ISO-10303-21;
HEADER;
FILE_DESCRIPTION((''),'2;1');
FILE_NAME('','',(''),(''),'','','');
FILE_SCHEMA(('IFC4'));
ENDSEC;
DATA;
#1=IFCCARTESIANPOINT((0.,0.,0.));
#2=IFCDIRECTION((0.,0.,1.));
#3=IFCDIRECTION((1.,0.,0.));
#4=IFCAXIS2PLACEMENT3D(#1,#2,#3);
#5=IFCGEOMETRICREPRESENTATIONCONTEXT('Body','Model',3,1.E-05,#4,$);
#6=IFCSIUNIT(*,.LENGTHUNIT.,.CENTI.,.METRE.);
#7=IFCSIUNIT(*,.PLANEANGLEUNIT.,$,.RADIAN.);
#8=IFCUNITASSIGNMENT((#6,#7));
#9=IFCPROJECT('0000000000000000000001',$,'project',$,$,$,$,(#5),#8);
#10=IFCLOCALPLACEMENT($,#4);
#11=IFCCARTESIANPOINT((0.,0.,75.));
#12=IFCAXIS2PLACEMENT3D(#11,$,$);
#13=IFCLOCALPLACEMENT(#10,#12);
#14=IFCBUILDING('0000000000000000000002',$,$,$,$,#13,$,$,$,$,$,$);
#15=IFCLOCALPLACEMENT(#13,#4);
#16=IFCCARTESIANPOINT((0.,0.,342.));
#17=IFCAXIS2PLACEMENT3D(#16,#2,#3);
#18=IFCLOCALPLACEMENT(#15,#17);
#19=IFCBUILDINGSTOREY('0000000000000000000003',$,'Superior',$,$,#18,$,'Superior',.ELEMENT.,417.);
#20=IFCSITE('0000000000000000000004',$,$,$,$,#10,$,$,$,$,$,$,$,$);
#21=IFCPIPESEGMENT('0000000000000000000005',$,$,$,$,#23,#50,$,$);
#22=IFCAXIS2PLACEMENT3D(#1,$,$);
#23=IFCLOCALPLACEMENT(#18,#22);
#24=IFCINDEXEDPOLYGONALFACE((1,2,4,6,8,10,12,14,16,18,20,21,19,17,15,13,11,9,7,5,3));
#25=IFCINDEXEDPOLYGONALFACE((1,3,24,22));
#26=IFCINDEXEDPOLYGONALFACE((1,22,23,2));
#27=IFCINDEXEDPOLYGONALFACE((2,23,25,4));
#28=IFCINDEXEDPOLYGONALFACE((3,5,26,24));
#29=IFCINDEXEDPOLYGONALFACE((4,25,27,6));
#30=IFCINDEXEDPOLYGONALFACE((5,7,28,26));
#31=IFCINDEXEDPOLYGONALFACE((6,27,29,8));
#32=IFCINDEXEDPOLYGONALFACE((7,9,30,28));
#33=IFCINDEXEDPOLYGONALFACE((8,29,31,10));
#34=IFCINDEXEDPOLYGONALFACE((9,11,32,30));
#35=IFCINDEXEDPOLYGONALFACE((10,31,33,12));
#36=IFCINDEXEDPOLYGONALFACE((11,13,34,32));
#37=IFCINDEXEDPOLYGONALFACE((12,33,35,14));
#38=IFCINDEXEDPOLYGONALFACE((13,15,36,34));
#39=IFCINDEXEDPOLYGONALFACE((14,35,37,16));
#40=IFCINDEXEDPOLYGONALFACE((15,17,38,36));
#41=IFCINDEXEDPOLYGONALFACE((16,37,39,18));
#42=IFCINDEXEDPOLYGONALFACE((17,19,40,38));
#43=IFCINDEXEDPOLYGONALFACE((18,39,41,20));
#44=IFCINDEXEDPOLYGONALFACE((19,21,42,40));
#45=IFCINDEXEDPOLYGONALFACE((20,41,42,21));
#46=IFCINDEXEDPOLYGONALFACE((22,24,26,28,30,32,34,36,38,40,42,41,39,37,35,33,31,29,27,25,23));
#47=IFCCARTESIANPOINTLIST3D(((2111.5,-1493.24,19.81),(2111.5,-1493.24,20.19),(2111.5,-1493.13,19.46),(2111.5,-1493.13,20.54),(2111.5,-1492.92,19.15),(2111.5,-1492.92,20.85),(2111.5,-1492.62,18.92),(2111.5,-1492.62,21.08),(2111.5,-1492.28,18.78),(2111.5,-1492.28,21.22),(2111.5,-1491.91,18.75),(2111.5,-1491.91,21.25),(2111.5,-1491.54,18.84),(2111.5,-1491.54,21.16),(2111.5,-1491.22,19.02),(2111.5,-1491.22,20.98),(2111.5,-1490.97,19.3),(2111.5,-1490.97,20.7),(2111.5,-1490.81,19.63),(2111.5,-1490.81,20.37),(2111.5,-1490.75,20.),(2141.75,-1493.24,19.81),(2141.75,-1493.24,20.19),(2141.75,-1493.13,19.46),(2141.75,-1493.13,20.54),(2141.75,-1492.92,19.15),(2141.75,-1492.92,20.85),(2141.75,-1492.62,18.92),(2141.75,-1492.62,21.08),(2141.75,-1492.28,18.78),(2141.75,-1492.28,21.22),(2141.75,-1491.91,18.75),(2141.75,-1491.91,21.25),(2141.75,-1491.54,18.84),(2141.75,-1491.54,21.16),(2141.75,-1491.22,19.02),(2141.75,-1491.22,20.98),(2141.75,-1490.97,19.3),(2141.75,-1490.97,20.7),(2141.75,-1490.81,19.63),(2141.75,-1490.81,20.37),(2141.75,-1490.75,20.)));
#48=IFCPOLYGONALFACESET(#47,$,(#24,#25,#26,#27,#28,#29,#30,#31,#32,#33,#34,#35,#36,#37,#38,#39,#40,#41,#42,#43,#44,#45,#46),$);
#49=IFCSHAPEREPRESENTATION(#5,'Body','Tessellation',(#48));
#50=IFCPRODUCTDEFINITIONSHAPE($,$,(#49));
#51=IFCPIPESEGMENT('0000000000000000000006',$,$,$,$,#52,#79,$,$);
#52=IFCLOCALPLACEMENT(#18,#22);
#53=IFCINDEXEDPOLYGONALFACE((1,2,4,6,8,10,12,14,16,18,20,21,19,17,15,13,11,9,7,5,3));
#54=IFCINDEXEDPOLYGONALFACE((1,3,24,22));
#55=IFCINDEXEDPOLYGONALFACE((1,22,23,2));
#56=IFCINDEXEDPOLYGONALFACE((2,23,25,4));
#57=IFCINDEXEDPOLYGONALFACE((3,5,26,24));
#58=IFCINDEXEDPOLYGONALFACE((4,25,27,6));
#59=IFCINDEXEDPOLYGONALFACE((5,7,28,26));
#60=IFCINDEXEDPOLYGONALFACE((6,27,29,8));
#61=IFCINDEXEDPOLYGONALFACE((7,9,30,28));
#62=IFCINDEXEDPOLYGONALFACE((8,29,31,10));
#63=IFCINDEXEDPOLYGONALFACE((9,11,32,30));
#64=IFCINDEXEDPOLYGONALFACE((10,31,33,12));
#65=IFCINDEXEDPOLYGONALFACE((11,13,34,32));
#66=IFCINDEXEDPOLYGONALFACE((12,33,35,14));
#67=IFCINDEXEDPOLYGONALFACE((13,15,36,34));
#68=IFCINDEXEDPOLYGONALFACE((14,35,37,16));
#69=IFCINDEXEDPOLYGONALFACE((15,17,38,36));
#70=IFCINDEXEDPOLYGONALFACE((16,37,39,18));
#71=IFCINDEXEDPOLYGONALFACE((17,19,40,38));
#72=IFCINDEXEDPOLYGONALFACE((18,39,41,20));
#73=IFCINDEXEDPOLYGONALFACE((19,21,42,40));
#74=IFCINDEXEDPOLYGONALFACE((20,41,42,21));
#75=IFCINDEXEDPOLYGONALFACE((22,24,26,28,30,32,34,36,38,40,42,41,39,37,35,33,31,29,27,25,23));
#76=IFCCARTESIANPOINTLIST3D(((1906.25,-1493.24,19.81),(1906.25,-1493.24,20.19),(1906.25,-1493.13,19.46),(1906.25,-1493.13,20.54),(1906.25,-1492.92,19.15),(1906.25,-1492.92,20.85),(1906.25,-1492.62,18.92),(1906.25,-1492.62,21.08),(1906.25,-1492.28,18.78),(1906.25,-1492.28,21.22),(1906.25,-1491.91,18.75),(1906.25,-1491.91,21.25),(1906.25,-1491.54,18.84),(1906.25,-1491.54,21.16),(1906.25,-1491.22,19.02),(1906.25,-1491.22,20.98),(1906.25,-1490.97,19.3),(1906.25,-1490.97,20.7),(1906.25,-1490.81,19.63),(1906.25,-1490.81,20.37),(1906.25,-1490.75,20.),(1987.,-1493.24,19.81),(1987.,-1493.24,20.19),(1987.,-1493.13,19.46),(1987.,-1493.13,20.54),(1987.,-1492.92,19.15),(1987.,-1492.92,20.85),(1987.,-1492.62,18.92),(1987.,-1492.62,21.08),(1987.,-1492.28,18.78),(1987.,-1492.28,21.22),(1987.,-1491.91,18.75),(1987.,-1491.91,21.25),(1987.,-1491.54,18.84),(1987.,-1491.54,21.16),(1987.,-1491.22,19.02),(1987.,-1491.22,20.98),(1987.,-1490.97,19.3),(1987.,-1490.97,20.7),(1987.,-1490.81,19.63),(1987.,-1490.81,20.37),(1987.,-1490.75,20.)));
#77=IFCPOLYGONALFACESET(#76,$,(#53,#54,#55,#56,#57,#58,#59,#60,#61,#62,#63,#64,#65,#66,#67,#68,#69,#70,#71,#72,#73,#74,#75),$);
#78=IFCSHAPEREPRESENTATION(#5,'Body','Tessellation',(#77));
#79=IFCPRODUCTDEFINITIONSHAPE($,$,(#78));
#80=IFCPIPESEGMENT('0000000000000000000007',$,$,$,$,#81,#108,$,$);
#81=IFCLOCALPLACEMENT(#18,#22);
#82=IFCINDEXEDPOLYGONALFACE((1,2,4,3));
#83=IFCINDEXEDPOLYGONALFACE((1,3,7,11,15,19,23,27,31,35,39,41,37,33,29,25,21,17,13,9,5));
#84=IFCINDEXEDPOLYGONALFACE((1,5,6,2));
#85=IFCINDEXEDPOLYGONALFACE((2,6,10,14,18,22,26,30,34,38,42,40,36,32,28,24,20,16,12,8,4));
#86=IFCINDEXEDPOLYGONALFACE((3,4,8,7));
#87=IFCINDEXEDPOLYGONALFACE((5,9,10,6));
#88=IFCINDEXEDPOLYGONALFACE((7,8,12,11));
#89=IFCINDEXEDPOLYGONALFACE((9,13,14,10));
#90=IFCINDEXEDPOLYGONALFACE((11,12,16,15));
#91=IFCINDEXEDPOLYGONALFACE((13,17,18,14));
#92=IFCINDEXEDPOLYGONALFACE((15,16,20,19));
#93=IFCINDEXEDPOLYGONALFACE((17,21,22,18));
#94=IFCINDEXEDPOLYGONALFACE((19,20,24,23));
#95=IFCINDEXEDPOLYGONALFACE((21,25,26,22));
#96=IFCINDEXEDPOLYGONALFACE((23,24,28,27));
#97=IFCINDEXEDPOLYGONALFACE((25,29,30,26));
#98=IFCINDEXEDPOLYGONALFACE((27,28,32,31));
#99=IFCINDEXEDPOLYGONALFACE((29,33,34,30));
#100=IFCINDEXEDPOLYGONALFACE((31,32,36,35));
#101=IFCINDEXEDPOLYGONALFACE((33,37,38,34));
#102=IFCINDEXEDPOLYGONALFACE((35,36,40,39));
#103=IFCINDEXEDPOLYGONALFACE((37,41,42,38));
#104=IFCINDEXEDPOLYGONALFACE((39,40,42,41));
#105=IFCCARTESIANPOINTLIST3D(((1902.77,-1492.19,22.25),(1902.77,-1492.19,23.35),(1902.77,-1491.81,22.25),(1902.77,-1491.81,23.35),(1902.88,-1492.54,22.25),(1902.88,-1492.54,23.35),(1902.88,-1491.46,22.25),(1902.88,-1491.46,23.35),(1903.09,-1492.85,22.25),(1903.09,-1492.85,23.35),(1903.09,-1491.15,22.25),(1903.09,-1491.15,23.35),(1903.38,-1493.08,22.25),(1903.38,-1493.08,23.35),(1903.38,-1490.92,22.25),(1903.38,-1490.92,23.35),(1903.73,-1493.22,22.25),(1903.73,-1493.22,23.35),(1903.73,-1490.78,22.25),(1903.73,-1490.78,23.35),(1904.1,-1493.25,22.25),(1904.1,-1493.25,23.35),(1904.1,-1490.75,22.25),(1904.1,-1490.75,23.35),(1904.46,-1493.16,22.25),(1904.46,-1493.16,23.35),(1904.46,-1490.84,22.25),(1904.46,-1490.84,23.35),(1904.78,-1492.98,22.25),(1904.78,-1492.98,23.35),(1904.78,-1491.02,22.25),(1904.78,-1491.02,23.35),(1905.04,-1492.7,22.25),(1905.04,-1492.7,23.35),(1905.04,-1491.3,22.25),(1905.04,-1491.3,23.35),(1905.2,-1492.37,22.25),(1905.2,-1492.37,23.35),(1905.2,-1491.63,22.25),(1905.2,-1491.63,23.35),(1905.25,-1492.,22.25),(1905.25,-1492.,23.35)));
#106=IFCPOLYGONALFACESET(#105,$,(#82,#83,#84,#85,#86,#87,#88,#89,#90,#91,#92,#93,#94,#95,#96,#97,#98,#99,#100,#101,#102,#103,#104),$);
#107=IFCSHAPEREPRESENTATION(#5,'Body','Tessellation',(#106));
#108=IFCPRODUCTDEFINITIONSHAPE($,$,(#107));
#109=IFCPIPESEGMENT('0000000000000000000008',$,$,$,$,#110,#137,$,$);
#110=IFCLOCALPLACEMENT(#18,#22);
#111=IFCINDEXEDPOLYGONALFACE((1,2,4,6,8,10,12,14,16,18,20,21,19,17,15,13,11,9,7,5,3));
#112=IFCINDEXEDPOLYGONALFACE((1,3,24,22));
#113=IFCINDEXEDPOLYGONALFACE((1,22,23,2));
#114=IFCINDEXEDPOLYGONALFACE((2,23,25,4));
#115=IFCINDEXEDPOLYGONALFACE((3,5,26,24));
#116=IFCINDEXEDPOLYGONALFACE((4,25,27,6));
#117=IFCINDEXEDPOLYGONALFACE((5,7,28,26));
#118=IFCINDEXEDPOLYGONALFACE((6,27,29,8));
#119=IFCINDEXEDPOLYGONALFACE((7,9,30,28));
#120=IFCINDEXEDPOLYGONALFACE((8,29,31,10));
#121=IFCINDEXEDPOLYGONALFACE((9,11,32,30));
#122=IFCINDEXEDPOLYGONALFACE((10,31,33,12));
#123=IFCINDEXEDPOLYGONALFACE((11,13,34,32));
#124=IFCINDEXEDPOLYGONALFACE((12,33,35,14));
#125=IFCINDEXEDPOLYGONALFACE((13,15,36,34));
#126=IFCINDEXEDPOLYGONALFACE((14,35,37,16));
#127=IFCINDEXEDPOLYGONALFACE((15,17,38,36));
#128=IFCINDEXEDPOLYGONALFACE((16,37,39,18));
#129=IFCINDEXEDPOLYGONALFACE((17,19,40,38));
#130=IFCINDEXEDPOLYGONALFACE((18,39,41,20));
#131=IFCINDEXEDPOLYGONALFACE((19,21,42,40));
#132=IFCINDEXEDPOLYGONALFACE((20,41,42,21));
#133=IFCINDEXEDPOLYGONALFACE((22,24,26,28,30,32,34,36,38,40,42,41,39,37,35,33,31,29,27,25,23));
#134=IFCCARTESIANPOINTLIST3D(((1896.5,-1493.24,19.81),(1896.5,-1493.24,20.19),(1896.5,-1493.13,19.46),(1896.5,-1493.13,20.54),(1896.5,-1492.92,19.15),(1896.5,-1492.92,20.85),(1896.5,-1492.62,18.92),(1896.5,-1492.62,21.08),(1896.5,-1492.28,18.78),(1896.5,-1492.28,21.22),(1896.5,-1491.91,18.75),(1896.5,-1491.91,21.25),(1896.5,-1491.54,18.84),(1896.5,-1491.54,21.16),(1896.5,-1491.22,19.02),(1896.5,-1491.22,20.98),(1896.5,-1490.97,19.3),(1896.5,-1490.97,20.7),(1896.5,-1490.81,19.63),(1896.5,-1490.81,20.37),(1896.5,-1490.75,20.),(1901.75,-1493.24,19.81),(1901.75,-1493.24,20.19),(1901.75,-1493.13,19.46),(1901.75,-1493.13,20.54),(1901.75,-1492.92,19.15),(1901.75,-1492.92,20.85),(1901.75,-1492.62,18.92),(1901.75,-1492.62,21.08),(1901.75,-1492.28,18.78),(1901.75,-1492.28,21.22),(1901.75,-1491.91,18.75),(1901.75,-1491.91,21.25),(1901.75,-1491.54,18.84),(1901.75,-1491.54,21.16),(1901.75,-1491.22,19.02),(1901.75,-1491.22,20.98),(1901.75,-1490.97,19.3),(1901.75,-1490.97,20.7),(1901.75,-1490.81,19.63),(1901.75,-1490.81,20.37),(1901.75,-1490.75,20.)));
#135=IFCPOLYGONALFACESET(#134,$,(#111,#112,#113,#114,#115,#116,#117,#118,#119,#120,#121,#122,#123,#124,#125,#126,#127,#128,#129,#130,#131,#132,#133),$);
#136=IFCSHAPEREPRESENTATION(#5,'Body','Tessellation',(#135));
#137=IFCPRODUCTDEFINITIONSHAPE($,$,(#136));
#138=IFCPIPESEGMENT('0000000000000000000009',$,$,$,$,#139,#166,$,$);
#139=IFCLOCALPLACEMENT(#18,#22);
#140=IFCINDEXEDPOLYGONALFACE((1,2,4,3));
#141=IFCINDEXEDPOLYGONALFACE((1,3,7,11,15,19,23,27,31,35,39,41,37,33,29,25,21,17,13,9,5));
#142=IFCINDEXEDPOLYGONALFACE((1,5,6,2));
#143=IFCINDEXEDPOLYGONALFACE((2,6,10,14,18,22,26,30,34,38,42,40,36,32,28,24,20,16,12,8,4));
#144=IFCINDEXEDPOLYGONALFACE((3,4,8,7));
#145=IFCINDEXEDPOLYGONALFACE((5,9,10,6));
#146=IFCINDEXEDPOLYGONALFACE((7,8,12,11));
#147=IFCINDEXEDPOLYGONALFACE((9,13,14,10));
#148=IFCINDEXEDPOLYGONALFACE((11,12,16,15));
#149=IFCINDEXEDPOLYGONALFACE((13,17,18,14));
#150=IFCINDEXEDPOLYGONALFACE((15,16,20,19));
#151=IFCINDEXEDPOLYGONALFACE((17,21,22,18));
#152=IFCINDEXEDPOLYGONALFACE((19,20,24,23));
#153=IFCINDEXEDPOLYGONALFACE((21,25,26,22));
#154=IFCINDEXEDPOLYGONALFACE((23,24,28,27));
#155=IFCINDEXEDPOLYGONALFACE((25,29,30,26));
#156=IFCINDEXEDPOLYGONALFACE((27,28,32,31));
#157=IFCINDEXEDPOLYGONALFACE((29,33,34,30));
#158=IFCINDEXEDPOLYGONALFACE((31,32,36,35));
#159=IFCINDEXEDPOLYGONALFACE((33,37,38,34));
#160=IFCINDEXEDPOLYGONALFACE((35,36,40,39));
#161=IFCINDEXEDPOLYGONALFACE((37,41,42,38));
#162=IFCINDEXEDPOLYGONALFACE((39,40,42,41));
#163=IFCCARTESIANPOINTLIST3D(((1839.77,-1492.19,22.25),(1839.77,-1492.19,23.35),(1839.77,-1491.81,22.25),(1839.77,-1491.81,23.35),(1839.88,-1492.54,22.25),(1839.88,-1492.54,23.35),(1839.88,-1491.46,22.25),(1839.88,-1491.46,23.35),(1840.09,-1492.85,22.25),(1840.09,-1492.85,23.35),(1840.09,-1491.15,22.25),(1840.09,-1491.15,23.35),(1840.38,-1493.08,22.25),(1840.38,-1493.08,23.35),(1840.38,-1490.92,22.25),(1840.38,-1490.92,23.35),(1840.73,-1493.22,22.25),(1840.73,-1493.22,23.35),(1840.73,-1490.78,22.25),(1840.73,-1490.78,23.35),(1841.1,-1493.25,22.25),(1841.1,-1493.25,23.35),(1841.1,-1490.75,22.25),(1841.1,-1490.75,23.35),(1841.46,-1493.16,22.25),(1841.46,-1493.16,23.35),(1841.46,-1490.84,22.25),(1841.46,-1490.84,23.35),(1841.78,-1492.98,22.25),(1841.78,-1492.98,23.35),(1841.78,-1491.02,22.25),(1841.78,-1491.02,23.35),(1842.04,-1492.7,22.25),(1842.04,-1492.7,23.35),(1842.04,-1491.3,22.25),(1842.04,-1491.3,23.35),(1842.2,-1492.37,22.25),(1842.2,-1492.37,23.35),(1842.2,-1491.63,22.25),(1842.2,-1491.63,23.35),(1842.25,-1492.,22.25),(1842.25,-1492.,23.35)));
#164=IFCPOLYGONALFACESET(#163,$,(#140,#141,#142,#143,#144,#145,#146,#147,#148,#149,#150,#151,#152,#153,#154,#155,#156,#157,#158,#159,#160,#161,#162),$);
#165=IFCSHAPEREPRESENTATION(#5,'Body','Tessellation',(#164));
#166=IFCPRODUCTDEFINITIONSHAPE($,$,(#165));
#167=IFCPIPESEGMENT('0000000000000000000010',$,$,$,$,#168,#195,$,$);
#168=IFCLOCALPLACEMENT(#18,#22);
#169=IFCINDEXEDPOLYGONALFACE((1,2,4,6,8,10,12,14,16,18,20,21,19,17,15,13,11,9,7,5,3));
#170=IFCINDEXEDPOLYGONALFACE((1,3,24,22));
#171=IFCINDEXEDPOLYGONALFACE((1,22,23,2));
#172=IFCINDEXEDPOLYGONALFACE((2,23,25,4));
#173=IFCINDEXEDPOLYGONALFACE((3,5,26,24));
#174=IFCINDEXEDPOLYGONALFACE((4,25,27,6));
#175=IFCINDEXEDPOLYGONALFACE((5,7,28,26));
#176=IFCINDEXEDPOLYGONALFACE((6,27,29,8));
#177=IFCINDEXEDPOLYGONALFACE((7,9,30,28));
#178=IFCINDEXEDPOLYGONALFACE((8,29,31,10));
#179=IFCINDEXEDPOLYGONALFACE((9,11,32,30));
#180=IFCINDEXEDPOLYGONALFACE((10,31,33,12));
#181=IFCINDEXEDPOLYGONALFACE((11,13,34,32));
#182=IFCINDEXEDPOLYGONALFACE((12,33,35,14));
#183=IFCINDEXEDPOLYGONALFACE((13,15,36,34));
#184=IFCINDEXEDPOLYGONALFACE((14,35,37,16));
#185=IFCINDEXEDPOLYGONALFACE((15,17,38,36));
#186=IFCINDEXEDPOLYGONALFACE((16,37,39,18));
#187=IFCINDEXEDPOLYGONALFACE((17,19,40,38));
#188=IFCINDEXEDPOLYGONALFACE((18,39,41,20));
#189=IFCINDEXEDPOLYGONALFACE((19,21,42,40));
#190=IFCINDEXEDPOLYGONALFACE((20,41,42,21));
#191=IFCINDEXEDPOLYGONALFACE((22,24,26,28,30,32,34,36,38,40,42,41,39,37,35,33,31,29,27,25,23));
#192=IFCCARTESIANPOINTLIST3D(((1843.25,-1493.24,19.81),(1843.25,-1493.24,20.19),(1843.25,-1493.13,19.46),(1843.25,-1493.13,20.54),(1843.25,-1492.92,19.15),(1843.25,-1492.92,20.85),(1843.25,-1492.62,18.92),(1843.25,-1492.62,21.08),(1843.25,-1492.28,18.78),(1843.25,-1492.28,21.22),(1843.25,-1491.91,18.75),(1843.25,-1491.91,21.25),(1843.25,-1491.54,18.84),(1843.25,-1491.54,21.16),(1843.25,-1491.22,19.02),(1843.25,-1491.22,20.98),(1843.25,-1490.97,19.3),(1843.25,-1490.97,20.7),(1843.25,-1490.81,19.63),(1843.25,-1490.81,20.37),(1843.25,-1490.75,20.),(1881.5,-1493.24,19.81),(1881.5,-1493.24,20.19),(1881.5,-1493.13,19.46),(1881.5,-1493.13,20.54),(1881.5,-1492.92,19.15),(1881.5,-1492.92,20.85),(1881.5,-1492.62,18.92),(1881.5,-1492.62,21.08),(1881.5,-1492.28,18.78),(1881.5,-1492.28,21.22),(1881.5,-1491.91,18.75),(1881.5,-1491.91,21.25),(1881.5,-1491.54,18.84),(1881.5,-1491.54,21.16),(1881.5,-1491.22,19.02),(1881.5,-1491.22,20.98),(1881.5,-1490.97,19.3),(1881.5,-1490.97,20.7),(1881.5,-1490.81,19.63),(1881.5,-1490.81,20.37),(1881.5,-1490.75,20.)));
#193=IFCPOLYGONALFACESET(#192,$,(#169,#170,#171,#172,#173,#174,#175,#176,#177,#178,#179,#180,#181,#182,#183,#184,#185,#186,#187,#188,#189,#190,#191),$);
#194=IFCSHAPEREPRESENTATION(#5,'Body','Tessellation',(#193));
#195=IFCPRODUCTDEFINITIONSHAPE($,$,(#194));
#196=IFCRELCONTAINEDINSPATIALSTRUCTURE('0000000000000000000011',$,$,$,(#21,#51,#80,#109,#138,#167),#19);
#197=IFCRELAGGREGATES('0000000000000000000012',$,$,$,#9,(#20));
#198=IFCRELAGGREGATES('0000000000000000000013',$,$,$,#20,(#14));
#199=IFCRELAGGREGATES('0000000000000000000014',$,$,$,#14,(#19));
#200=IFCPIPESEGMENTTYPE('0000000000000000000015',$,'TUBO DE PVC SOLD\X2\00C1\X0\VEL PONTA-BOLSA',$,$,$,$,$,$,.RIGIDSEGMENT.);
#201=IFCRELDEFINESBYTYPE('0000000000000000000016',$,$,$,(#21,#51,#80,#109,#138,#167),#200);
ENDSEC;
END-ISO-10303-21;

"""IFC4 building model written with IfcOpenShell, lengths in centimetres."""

from ifc_helpers import new_model, si_unit, frame, origin_with_axes, origin_2d_with_axis, place, context, project, spatial, circle, extrude, type_object, element, save


model = new_model("IFC4")

# Units and contexts
model_context = context("Model", 3, precision=1e-05, world=origin_with_axes(), identifier="Body")
ifc_project = project(units=[si_unit("LENGTHUNIT", "METRE", prefix="CENTI"), si_unit("PLANEANGLEUNIT", "RADIAN")], contexts=[model_context])

# Site, building, storey
site_placement = place(None, origin_with_axes())
site = spatial("IfcSite", under=ifc_project, at=site_placement)
building_placement = place(site_placement, frame((0.0, 0.0, 75.0)))
building = spatial("IfcBuilding", under=site, at=building_placement)
placement = place(building_placement, origin_with_axes())
storey_placement = place(placement, frame((0.0, 0.0, 342.0), z_axis=(0.0, 0.0, 1.0), x_axis=(1.0, 0.0, 0.0)))
storey = spatial("IfcBuildingStorey", under=building, at=storey_placement, Name="Superior", LongName="Superior", CompositionType="ELEMENT", Elevation=417.0)

# Pipe segments
pipe_segment_type_1 = type_object("IfcPipeSegmentType", Name="TUBO DE PVC SOLDÁVEL PONTA-BOLSA", PredefinedType="RIGIDSEGMENT")
pipe_segment_1_placement = place(storey_placement, frame((2126.63, -1492.0, 21.25), z_axis=(0.0, 0.0, 1.0), x_axis=(1.0, 0.0, 0.0)))
element("IfcPipeSegment", 1, at=pipe_segment_1_placement, inside=storey, type_object=pipe_segment_type_1, context=model_context, shape_type="SolidModel", body=[
    extrude(circle(Radius=1.25, at=origin_2d_with_axis()), frame((15.12, 0.0, -1.25), z_axis=(-1.0, 0.0, 0.0), x_axis=(0.0, 1.0, 0.0)), (0.0, 0.0, 1.0), 30.25),
])
pipe_segment_2_placement = place(storey_placement, frame((1946.63, -1492.0, 21.25), z_axis=(0.0, 0.0, 1.0), x_axis=(1.0, 0.0, 0.0)))
element("IfcPipeSegment", 2, at=pipe_segment_2_placement, inside=storey, type_object=pipe_segment_type_1, context=model_context, shape_type="SolidModel", body=[
    extrude(circle(Radius=1.25, at=origin_2d_with_axis()), frame((40.38, 0.0, -1.25), z_axis=(-1.0, 0.0, 0.0), x_axis=(0.0, 1.0, 0.0)), (0.0, 0.0, 1.0), 80.75),
])
pipe_segment_3_placement = place(storey_placement, frame((1904.0, -1492.0, 23.35), z_axis=(0.0, 0.0, 1.0), x_axis=(1.0, 0.0, 0.0)))
element("IfcPipeSegment", 3, at=pipe_segment_3_placement, inside=storey, type_object=pipe_segment_type_1, context=model_context, shape_type="SolidModel", body=[
    extrude(circle(Radius=1.25, at=origin_2d_with_axis()), frame((0.0, 0.0, -1.1), z_axis=(0.0, 0.0, 1.0), x_axis=(1.0, 0.0, 0.0)), (0.0, 0.0, 1.0), 1.1),
])
pipe_segment_4_placement = place(storey_placement, frame((1899.13, -1492.0, 21.25), z_axis=(0.0, 0.0, 1.0), x_axis=(1.0, 0.0, 0.0)))
element("IfcPipeSegment", 4, at=pipe_segment_4_placement, inside=storey, type_object=pipe_segment_type_1, context=model_context, shape_type="SolidModel", body=[
    extrude(circle(Radius=1.25, at=origin_2d_with_axis()), frame((2.62, 0.0, -1.25), z_axis=(-1.0, 0.0, 0.0), x_axis=(0.0, 1.0, 0.0)), (0.0, 0.0, 1.0), 5.25),
])
pipe_segment_5_placement = place(storey_placement, frame((1841.0, -1492.0, 23.35), z_axis=(0.0, 0.0, 1.0), x_axis=(1.0, 0.0, 0.0)))
element("IfcPipeSegment", 5, at=pipe_segment_5_placement, inside=storey, type_object=pipe_segment_type_1, context=model_context, shape_type="SolidModel", body=[
    extrude(circle(Radius=1.25, at=origin_2d_with_axis()), frame((0.0, 0.0, -1.1), z_axis=(0.0, 0.0, 1.0), x_axis=(1.0, 0.0, 0.0)), (0.0, 0.0, 1.0), 1.1),
])
pipe_segment_6_placement = place(storey_placement, frame((1862.38, -1492.0, 21.25), z_axis=(0.0, 0.0, 1.0), x_axis=(1.0, 0.0, 0.0)))
element("IfcPipeSegment", 6, at=pipe_segment_6_placement, inside=storey, type_object=pipe_segment_type_1, context=model_context, shape_type="SolidModel", body=[
    extrude(circle(Radius=1.25, at=origin_2d_with_axis()), frame((19.12, 0.0, -1.25), z_axis=(-1.0, 0.0, 0.0), x_axis=(0.0, 1.0, 0.0)), (0.0, 0.0, 1.0), 38.25),
])

save(model, "model.ifc")
